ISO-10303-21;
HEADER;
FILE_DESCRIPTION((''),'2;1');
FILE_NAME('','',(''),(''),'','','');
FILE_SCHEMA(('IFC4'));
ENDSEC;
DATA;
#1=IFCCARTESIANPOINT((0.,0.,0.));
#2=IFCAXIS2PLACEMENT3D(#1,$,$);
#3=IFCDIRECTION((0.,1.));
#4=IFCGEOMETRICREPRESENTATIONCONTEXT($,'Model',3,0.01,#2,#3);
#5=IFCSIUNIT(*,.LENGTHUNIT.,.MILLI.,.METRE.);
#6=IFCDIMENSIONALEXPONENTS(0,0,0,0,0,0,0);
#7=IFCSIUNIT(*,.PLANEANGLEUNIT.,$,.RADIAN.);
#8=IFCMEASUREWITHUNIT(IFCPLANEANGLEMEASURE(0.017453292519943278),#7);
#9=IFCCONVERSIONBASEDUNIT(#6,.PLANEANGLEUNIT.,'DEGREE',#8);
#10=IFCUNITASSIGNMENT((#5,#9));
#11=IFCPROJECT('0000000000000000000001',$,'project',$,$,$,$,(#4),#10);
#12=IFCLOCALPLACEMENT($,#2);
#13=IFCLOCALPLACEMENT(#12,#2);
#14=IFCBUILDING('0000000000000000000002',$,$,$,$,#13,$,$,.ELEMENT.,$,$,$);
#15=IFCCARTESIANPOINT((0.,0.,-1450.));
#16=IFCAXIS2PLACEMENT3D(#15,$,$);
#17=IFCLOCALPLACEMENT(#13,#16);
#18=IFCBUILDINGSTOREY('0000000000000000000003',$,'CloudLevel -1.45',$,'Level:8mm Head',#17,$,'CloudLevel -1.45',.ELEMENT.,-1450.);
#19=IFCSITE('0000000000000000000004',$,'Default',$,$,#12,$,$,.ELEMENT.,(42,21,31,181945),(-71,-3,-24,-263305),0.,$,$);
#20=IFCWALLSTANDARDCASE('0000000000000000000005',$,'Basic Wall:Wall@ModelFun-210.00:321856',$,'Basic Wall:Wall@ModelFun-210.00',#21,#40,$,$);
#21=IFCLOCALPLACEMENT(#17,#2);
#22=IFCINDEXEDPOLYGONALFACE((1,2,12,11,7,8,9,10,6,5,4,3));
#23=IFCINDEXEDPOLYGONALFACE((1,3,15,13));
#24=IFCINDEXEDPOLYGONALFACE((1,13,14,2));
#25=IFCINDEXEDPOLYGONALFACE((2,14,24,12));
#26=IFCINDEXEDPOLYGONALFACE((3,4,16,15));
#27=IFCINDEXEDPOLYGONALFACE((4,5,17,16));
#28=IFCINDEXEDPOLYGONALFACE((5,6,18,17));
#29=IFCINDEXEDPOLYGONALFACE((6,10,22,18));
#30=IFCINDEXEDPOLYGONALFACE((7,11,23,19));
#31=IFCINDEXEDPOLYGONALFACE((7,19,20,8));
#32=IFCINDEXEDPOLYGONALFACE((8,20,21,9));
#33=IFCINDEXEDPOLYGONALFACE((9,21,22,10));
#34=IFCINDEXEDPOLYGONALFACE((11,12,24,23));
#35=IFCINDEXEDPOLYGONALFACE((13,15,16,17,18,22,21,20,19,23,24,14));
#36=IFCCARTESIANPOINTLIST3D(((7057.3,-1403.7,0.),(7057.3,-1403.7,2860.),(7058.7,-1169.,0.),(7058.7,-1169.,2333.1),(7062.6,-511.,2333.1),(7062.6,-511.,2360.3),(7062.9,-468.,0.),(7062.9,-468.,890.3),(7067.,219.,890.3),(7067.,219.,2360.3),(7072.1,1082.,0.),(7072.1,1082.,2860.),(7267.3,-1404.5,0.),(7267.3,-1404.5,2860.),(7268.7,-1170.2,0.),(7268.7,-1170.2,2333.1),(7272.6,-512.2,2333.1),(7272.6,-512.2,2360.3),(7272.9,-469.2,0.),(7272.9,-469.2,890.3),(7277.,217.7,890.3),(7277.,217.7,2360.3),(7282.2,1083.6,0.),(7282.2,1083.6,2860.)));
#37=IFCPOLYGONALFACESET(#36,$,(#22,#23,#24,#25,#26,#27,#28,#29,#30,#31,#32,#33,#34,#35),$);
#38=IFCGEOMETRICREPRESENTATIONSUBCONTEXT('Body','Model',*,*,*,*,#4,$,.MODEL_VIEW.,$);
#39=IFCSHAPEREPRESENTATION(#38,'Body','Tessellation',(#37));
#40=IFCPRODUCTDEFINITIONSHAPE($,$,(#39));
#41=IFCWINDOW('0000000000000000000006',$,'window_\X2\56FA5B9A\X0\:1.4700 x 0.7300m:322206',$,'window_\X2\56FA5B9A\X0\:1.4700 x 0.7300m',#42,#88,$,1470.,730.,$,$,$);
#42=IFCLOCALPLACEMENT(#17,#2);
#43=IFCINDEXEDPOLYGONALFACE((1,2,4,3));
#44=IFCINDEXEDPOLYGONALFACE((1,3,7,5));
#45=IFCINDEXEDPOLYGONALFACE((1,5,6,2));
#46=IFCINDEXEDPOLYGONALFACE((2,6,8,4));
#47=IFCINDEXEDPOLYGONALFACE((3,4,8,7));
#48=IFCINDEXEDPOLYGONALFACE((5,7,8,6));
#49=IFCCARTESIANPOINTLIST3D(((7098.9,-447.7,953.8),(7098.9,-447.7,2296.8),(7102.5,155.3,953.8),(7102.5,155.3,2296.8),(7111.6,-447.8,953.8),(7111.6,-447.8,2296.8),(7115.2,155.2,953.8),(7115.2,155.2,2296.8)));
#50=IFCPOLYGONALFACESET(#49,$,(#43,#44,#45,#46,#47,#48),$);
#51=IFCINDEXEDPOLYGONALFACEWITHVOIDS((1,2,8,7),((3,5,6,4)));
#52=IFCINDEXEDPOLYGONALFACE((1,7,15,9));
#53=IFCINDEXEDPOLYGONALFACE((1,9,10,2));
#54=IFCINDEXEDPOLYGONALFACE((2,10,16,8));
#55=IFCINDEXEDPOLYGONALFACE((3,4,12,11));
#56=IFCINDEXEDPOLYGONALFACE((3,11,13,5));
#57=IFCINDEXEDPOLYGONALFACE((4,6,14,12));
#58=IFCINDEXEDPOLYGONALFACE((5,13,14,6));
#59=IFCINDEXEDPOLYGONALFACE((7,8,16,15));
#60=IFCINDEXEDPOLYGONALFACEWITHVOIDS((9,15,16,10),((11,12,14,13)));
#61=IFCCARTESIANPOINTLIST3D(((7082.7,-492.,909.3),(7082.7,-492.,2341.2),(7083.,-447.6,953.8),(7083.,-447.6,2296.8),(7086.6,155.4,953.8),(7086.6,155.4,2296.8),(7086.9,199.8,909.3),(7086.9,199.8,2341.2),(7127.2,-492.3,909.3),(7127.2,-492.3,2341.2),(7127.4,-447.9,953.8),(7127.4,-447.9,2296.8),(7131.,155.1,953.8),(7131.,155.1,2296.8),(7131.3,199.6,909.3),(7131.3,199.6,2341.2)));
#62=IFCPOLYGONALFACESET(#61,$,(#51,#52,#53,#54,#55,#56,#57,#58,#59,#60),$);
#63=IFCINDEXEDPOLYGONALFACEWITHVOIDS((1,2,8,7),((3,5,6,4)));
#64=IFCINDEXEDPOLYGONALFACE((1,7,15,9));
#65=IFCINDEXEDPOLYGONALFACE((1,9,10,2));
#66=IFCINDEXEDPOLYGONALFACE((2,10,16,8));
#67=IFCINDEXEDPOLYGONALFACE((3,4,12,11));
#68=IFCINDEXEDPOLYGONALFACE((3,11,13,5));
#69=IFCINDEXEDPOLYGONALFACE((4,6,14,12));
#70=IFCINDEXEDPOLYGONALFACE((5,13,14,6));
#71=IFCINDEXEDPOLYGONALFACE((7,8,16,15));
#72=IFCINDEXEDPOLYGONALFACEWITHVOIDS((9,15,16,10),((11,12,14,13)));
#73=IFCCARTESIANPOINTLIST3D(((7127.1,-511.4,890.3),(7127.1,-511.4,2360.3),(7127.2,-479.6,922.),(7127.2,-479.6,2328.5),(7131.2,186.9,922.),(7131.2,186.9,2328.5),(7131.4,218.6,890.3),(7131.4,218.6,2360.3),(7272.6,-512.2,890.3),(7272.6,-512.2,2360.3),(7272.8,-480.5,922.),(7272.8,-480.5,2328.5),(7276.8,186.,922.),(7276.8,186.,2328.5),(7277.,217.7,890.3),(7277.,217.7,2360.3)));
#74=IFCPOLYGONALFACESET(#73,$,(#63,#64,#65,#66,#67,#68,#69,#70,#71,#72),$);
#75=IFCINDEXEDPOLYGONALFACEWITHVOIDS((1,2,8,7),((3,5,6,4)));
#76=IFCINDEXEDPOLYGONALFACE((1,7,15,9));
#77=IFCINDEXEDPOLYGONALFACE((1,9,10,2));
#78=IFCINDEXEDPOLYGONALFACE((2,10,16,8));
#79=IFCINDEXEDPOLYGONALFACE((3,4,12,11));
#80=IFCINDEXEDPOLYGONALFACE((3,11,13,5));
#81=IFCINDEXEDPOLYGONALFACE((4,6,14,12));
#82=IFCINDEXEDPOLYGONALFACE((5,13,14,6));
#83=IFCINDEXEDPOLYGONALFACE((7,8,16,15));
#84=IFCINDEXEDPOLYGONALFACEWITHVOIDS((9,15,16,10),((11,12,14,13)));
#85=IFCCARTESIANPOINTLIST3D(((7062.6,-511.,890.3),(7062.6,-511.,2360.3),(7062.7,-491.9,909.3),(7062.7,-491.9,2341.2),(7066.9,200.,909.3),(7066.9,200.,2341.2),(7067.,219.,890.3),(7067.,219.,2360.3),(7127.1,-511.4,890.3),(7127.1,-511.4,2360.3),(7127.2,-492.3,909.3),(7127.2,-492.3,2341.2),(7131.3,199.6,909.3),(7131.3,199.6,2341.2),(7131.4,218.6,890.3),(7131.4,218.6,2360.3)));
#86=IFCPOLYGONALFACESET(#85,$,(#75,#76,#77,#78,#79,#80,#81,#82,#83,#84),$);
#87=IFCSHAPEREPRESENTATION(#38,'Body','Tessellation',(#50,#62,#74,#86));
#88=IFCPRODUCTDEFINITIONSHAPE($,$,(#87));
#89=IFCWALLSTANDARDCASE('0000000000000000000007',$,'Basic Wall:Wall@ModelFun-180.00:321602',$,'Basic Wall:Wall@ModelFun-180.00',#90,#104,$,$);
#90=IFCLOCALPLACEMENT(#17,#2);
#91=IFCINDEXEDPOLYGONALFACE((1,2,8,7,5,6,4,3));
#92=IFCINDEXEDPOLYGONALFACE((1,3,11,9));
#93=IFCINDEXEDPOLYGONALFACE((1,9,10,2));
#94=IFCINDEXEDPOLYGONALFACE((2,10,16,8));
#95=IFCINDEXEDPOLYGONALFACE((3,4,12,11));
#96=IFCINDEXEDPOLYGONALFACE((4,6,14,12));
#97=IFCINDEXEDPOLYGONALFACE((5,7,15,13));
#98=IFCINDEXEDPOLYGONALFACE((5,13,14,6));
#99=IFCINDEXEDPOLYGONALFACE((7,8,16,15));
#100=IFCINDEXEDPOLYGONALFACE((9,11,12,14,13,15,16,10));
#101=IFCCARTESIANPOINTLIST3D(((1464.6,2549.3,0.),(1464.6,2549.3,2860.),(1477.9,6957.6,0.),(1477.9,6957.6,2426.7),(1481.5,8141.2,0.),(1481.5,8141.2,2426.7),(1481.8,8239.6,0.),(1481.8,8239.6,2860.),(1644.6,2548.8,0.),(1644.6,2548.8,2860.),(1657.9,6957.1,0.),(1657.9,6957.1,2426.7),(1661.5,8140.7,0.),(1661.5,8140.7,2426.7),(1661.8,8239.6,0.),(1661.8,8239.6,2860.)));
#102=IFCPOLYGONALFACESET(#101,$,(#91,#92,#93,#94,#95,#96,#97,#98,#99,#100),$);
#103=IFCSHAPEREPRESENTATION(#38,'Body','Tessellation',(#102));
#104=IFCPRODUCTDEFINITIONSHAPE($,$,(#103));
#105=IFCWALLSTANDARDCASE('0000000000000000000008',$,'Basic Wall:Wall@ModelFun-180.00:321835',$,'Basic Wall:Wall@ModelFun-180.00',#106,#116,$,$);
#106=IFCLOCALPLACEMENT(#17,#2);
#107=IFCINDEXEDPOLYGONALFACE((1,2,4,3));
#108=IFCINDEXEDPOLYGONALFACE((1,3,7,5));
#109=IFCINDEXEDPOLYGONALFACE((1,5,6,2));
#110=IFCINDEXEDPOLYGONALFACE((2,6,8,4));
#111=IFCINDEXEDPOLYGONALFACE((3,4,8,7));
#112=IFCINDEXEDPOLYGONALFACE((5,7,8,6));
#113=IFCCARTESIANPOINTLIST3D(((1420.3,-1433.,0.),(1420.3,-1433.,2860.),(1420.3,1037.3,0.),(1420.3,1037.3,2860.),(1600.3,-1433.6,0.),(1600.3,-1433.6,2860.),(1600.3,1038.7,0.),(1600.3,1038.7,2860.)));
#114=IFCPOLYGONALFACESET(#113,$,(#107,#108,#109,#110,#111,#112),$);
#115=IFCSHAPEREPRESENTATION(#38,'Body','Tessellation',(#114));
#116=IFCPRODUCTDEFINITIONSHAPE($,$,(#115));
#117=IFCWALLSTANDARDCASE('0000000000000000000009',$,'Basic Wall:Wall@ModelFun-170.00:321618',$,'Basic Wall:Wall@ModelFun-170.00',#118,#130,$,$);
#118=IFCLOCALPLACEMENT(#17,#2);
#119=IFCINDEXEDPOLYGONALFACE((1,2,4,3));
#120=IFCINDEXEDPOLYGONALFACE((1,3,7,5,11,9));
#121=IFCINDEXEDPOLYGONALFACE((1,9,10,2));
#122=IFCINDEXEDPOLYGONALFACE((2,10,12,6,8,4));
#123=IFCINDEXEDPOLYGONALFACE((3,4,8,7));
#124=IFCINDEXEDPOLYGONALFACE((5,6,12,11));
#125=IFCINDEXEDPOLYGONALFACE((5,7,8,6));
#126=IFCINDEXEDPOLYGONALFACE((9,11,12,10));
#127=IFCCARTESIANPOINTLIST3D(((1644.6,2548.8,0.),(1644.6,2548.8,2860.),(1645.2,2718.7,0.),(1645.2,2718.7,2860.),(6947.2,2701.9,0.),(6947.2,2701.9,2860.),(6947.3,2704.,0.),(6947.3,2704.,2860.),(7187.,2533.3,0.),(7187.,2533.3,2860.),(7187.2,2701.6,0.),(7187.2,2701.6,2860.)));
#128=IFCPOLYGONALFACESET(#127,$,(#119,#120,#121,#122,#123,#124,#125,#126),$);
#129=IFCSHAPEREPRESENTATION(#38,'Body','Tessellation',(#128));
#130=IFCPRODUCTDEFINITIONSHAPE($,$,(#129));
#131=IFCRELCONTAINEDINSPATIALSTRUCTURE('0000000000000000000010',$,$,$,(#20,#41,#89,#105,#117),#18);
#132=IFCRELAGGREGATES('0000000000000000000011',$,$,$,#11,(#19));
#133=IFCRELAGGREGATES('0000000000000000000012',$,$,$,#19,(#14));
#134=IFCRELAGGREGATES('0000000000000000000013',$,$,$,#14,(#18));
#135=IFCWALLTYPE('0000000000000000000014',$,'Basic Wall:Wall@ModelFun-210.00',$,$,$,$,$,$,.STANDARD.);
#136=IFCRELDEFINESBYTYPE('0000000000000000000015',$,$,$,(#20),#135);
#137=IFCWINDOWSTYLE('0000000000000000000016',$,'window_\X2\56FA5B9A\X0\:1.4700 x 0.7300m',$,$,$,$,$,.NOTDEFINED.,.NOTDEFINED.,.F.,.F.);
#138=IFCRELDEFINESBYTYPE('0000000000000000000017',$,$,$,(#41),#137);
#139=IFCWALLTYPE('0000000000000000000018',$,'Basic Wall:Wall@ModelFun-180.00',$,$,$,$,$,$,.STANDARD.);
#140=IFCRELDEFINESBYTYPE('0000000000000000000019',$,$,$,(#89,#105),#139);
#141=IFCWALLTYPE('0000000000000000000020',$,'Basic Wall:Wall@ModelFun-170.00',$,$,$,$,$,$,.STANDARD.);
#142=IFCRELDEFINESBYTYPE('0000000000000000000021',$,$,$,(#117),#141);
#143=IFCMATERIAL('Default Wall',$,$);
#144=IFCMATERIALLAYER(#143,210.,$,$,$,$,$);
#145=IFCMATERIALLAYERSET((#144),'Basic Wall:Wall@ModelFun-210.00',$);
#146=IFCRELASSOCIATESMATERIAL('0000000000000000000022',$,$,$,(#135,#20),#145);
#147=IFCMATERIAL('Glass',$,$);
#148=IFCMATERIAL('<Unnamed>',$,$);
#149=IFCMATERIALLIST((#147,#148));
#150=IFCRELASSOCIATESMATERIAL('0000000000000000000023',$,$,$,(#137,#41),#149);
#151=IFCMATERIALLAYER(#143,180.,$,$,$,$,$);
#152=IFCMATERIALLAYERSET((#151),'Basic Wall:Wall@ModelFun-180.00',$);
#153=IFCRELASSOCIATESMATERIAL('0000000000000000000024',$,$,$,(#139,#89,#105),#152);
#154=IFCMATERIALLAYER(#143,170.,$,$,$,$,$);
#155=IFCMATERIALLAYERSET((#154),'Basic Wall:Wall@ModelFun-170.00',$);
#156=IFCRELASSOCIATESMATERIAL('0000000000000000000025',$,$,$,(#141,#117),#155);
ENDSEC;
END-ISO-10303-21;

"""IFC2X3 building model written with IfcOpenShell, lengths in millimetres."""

from ifc_helpers import new_model, entity, si_unit, converted_unit, direction, frame, frame_2d, origin, place, context, subcontext, project, spatial, polyline, rectangle, outline, extrude, source, transform, mapped, material, material_list, layer, layer_set, layer_usage, type_object, type_shapes, element, fill, save


model = new_model("IFC2X3")

# Units and contexts
model_context = context("Model", 3, precision=0.01, world=origin(), true_north=direction((0.0, 1.0)))
body_context = subcontext(model_context, "Body", "Model", "MODEL_VIEW")
ifc_project = project(units=[si_unit("LENGTHUNIT", "METRE", prefix="MILLI"), converted_unit("PLANEANGLEUNIT", "DEGREE", entity("IfcPlaneAngleMeasure", 0.017453292519943278), si_unit("PLANEANGLEUNIT", "RADIAN"), dimensions=[0, 0, 0, 0, 0, 0, 0])], contexts=[model_context])

# Site, building, storey
site_placement = place(None, origin())
site = spatial("IfcSite", under=ifc_project, at=site_placement, Name="Default", CompositionType="ELEMENT", RefLatitude=(42, 21, 31, 181945), RefLongitude=(-71, -3, -24, -263305), RefElevation=0.0)
building_placement = place(site_placement, origin())
building = spatial("IfcBuilding", under=site, at=building_placement, CompositionType="ELEMENT")
storey_placement = place(building_placement, frame((0.0, 0.0, -1450.0)))
storey = spatial("IfcBuildingStorey", under=building, at=storey_placement, Name="CloudLevel -1.45", ObjectType="Level:8mm Head", LongName="CloudLevel -1.45", CompositionType="ELEMENT", Elevation=-1450.0)

# Shared definitions
ifc_material_1 = material(Name="Default Wall")
ifc_material_2 = material(Name="Glass")
ifc_material_3 = material(Name="<Unnamed>")
ifc_material_list = material_list([ifc_material_2, ifc_material_3])

# Wall, openings, window
ifc_layer_1 = layer(ifc_material_1, 210.0)
ifc_layer_set_1 = layer_set([ifc_layer_1], Name="Basic Wall:Wall@ModelFun-210.00")
ifc_layer_usage_1 = layer_usage(ifc_layer_set_1, "AXIS2", "NEGATIVE", 105.0)
wall_type_1 = type_object("IfcWallType", Name="Basic Wall:Wall@ModelFun-210.00", PredefinedType="STANDARD", material=ifc_layer_set_1)
wall_1_placement = place(storey_placement, frame((7177.2, 1084.2, 0.0), z_axis=(0.0, 0.0, 1.0), x_axis=(-0.00599, -0.999982, 0.0)))
wall_1 = element("IfcWallStandardCase", 1, at=wall_1_placement, inside=storey, type_object=wall_type_1, material=ifc_layer_usage_1, Name="Basic Wall:Wall@ModelFun-210.00:321856", ObjectType="Basic Wall:Wall@ModelFun-210.00", context=body_context, shape_type="SweptSolid", body=[
    extrude(outline(polyline([(2.9, -105.0), (2488.6, -105.0), (2488.2, 105.0), (0.0, 105.0), (2.9, -105.0)])), origin(), (0.0, 0.0, 1.0), 2860.0),
])
opening_1_placement = place(wall_1_placement, frame((1552.9, -105.0, -66.6)))
element("IfcOpeningElement", 2, at=opening_1_placement, cuts=wall_1, ObjectType="Opening", context=body_context, shape_type="SweptSolid", body=[
    extrude(rectangle(XDim=701.0, YDim=2399.7, at=frame_2d((1199.9, 350.5), x_axis=(0.0, 1.0))), frame((0.0, 0.0, 0.0), z_axis=(0.0, 1.0, 0.0), x_axis=(0.0, 0.0, 1.0)), (0.0, 0.0, 1.0), 210.0),
])
opening_2_placement = place(wall_1_placement, frame((1595.9, 105.0, 890.3)))
opening_2 = element("IfcOpeningElement", 3, at=opening_2_placement, cuts=wall_1, ObjectType="Opening", context=body_context, shape_type="SweptSolid", body=[
    extrude(rectangle(XDim=1470.0, YDim=730.0, at=frame_2d((735.0, 365.0), x_axis=(-1.0, 0.0))), frame((0.0, 0.0, 0.0), z_axis=(0.0, -1.0, 0.0), x_axis=(0.0, 0.0, 1.0)), (0.0, 0.0, 1.0), 210.0),
])
window_style_1 = type_object("IfcWindowStyle", Name="window_固定:1.4700 x 0.7300m", ConstructionType="NOTDEFINED", OperationType="NOTDEFINED", ParameterTakesPrecedence=False, Sizeable=False, material=ifc_material_list)
shared_shape_1 = source(origin(), body_context, "Body", "SweptSolid", [
    extrude(rectangle(XDim=603.0, YDim=12.7, at=frame_2d((0.0, 0.0), x_axis=(1.0, 0.0))), frame((441.2, 167.8, 63.5)), (0.0, 0.0, 1.0), 1343.0),
    extrude(outline(polyline([(-345.9, -715.9), (345.9, -715.9), (345.9, 715.9), (-345.9, 715.9), (-345.9, -715.9)]), holes=[polyline([(-301.5, -671.5), (-301.5, 671.5), (301.5, 671.5), (301.5, -671.5), (-301.5, -671.5)])]), frame((441.2, 190.0, 735.0), z_axis=(0.0, -1.0, 0.0), x_axis=(-1.0, 0.0, 0.0)), (0.0, 0.0, 1.0), 44.4),
    extrude(outline(polyline([(-365.0, -735.0), (365.0, -735.0), (365.0, 735.0), (-365.0, 735.0), (-365.0, -735.0)]), holes=[polyline([(-333.2, -703.2), (-333.2, 703.2), (333.2, 703.2), (333.2, -703.2), (-333.2, -703.2)])]), frame((441.2, 145.5, 735.0), z_axis=(0.0, -1.0, 0.0), x_axis=(-1.0, 0.0, 0.0)), (0.0, 0.0, 1.0), 145.5),
    extrude(outline(polyline([(-735.0, -365.0), (735.0, -365.0), (735.0, 365.0), (-735.0, 365.0), (-735.0, -365.0)]), holes=[polyline([(-715.9, -345.9), (-715.9, 345.9), (715.9, 345.9), (715.9, -345.9), (-715.9, -345.9)])]), frame((441.2, 210.0, 735.0), z_axis=(0.0, -1.0, 0.0), x_axis=(0.0, 0.0, -1.0)), (0.0, 0.0, 1.0), 64.4),
])
type_shapes(window_style_1, [shared_shape_1])
window_1_placement = place(opening_2_placement, frame((76.2, 0.0, 0.0), z_axis=(0.0, 0.0, 1.0), x_axis=(-1.0, 0.0, 0.0)))
window_1 = element("IfcWindow", 4, at=window_1_placement, inside=storey, type_object=window_style_1, material=ifc_material_list, Name="window_固定:1.4700 x 0.7300m:322206", ObjectType="window_固定:1.4700 x 0.7300m", OverallHeight=1470.0, OverallWidth=730.0, context=body_context, shape_type="MappedRepresentation", body=[
    mapped(shared_shape_1, transform((0.0, 0.0, 0.0), scale=1.0)),
])
fill(opening_2, window_1)

# Wall, opening
ifc_layer_2 = layer(ifc_material_1, 180.0)
ifc_layer_set_2 = layer_set([ifc_layer_2], Name="Basic Wall:Wall@ModelFun-180.00")
ifc_layer_usage_2 = layer_usage(ifc_layer_set_2, "AXIS2", "NEGATIVE", 90.0)
wall_type_2 = type_object("IfcWallType", Name="Basic Wall:Wall@ModelFun-180.00", PredefinedType="STANDARD", material=ifc_layer_set_2)
wall_2_placement = place(storey_placement, frame((1554.6, 2549.0, 0.0), z_axis=(0.0, 0.0, 1.0), x_axis=(0.003007, 0.999995, 0.0)))
wall_2 = element("IfcWallStandardCase", 5, at=wall_2_placement, inside=storey, type_object=wall_type_2, material=ifc_layer_usage_2, Name="Basic Wall:Wall@ModelFun-180.00:321602", ObjectType="Basic Wall:Wall@ModelFun-180.00", context=body_context, shape_type="SweptSolid", body=[
    extrude(outline(polyline([(0.0, -90.0), (170.0, -90.0), (4156.1, -90.0), (4396.1, -90.0), (5690.9, -90.0), (5690.4, 90.0), (0.0, 90.0), (0.0, -90.0)])), origin(), (0.0, 0.0, 1.0), 2860.0),
])
opening_3_placement = place(wall_2_placement, frame((4408.4, -90.0, 0.0)))
element("IfcOpeningElement", 6, at=opening_3_placement, cuts=wall_2, ObjectType="Opening", context=body_context, shape_type="SweptSolid", body=[
    extrude(rectangle(XDim=1183.6, YDim=2426.7, at=frame_2d((1213.4, 591.8), x_axis=(0.0, 1.0))), frame((0.0, 0.0, 0.0), z_axis=(0.0, 1.0, 0.0), x_axis=(0.0, 0.0, 1.0)), (0.0, 0.0, 1.0), 180.0),
])

# Wall
wall_3_placement = place(storey_placement, frame((1510.3, 1038.7, 0.0), z_axis=(0.0, 0.0, 1.0), x_axis=(0.0, -1.0, 0.0)))
element("IfcWallStandardCase", 7, at=wall_3_placement, inside=storey, type_object=wall_type_2, material=ifc_layer_usage_2, Name="Basic Wall:Wall@ModelFun-180.00:321835", ObjectType="Basic Wall:Wall@ModelFun-180.00", context=body_context, shape_type="SweptSolid", body=[
    extrude(outline(polyline([(2471.7, -90.0), (2472.3, 90.0), (0.0, 90.0), (1.4, -90.0), (2471.7, -90.0)])), origin(), (0.0, 0.0, 1.0), 2860.0),
])

# Wall, opening
ifc_layer_3 = layer(ifc_material_1, 170.0)
ifc_layer_set_3 = layer_set([ifc_layer_3], Name="Basic Wall:Wall@ModelFun-170.00")
ifc_layer_usage_3 = layer_usage(ifc_layer_set_3, "AXIS2", "NEGATIVE", 85.0)
wall_type_3 = type_object("IfcWallType", Name="Basic Wall:Wall@ModelFun-170.00", PredefinedType="STANDARD", material=ifc_layer_set_3)
wall_4_placement = place(storey_placement, frame((1644.9, 2633.7, 0.0), z_axis=(0.0, 0.0, 1.0), x_axis=(0.999996, -0.002791, 0.0)))
wall_4 = element("IfcWallStandardCase", 8, at=wall_4_placement, inside=storey, type_object=wall_type_3, material=ifc_layer_usage_3, Name="Basic Wall:Wall@ModelFun-170.00:321618", ObjectType="Basic Wall:Wall@ModelFun-170.00", context=body_context, shape_type="SweptSolid", body=[
    extrude(outline(polyline([(5542.4, -85.0), (5542.2, 83.3), (5302.2, 83.0), (5302.2, 85.0), (0.0, 85.0), (0.0, -85.0), (5542.4, -85.0)])), origin(), (0.0, 0.0, 1.0), 2860.0),
])
opening_4_placement = place(wall_4_placement, frame((0.0, 0.0, 0.0), z_axis=(0.0, 0.0, 1.0), x_axis=(0.999996, 0.002791, 0.0)))
element("IfcOpeningElement", 9, at=opening_4_placement, cuts=wall_4, ObjectType="Opening", context=body_context, shape_type="SweptSolid", body=[
    extrude(rectangle(XDim=2650.0, YDim=240.0, at=frame_2d((0.0, 0.0), x_axis=(0.0, 1.0))), frame((5422.2, 83.1, 1325.0), z_axis=(-0.001507, 0.999999, 0.0), x_axis=(0.999999, 0.001507, 0.0)), (0.0, 0.0, 1.0), 1208.3),
])

save(model, "model.ifc")
